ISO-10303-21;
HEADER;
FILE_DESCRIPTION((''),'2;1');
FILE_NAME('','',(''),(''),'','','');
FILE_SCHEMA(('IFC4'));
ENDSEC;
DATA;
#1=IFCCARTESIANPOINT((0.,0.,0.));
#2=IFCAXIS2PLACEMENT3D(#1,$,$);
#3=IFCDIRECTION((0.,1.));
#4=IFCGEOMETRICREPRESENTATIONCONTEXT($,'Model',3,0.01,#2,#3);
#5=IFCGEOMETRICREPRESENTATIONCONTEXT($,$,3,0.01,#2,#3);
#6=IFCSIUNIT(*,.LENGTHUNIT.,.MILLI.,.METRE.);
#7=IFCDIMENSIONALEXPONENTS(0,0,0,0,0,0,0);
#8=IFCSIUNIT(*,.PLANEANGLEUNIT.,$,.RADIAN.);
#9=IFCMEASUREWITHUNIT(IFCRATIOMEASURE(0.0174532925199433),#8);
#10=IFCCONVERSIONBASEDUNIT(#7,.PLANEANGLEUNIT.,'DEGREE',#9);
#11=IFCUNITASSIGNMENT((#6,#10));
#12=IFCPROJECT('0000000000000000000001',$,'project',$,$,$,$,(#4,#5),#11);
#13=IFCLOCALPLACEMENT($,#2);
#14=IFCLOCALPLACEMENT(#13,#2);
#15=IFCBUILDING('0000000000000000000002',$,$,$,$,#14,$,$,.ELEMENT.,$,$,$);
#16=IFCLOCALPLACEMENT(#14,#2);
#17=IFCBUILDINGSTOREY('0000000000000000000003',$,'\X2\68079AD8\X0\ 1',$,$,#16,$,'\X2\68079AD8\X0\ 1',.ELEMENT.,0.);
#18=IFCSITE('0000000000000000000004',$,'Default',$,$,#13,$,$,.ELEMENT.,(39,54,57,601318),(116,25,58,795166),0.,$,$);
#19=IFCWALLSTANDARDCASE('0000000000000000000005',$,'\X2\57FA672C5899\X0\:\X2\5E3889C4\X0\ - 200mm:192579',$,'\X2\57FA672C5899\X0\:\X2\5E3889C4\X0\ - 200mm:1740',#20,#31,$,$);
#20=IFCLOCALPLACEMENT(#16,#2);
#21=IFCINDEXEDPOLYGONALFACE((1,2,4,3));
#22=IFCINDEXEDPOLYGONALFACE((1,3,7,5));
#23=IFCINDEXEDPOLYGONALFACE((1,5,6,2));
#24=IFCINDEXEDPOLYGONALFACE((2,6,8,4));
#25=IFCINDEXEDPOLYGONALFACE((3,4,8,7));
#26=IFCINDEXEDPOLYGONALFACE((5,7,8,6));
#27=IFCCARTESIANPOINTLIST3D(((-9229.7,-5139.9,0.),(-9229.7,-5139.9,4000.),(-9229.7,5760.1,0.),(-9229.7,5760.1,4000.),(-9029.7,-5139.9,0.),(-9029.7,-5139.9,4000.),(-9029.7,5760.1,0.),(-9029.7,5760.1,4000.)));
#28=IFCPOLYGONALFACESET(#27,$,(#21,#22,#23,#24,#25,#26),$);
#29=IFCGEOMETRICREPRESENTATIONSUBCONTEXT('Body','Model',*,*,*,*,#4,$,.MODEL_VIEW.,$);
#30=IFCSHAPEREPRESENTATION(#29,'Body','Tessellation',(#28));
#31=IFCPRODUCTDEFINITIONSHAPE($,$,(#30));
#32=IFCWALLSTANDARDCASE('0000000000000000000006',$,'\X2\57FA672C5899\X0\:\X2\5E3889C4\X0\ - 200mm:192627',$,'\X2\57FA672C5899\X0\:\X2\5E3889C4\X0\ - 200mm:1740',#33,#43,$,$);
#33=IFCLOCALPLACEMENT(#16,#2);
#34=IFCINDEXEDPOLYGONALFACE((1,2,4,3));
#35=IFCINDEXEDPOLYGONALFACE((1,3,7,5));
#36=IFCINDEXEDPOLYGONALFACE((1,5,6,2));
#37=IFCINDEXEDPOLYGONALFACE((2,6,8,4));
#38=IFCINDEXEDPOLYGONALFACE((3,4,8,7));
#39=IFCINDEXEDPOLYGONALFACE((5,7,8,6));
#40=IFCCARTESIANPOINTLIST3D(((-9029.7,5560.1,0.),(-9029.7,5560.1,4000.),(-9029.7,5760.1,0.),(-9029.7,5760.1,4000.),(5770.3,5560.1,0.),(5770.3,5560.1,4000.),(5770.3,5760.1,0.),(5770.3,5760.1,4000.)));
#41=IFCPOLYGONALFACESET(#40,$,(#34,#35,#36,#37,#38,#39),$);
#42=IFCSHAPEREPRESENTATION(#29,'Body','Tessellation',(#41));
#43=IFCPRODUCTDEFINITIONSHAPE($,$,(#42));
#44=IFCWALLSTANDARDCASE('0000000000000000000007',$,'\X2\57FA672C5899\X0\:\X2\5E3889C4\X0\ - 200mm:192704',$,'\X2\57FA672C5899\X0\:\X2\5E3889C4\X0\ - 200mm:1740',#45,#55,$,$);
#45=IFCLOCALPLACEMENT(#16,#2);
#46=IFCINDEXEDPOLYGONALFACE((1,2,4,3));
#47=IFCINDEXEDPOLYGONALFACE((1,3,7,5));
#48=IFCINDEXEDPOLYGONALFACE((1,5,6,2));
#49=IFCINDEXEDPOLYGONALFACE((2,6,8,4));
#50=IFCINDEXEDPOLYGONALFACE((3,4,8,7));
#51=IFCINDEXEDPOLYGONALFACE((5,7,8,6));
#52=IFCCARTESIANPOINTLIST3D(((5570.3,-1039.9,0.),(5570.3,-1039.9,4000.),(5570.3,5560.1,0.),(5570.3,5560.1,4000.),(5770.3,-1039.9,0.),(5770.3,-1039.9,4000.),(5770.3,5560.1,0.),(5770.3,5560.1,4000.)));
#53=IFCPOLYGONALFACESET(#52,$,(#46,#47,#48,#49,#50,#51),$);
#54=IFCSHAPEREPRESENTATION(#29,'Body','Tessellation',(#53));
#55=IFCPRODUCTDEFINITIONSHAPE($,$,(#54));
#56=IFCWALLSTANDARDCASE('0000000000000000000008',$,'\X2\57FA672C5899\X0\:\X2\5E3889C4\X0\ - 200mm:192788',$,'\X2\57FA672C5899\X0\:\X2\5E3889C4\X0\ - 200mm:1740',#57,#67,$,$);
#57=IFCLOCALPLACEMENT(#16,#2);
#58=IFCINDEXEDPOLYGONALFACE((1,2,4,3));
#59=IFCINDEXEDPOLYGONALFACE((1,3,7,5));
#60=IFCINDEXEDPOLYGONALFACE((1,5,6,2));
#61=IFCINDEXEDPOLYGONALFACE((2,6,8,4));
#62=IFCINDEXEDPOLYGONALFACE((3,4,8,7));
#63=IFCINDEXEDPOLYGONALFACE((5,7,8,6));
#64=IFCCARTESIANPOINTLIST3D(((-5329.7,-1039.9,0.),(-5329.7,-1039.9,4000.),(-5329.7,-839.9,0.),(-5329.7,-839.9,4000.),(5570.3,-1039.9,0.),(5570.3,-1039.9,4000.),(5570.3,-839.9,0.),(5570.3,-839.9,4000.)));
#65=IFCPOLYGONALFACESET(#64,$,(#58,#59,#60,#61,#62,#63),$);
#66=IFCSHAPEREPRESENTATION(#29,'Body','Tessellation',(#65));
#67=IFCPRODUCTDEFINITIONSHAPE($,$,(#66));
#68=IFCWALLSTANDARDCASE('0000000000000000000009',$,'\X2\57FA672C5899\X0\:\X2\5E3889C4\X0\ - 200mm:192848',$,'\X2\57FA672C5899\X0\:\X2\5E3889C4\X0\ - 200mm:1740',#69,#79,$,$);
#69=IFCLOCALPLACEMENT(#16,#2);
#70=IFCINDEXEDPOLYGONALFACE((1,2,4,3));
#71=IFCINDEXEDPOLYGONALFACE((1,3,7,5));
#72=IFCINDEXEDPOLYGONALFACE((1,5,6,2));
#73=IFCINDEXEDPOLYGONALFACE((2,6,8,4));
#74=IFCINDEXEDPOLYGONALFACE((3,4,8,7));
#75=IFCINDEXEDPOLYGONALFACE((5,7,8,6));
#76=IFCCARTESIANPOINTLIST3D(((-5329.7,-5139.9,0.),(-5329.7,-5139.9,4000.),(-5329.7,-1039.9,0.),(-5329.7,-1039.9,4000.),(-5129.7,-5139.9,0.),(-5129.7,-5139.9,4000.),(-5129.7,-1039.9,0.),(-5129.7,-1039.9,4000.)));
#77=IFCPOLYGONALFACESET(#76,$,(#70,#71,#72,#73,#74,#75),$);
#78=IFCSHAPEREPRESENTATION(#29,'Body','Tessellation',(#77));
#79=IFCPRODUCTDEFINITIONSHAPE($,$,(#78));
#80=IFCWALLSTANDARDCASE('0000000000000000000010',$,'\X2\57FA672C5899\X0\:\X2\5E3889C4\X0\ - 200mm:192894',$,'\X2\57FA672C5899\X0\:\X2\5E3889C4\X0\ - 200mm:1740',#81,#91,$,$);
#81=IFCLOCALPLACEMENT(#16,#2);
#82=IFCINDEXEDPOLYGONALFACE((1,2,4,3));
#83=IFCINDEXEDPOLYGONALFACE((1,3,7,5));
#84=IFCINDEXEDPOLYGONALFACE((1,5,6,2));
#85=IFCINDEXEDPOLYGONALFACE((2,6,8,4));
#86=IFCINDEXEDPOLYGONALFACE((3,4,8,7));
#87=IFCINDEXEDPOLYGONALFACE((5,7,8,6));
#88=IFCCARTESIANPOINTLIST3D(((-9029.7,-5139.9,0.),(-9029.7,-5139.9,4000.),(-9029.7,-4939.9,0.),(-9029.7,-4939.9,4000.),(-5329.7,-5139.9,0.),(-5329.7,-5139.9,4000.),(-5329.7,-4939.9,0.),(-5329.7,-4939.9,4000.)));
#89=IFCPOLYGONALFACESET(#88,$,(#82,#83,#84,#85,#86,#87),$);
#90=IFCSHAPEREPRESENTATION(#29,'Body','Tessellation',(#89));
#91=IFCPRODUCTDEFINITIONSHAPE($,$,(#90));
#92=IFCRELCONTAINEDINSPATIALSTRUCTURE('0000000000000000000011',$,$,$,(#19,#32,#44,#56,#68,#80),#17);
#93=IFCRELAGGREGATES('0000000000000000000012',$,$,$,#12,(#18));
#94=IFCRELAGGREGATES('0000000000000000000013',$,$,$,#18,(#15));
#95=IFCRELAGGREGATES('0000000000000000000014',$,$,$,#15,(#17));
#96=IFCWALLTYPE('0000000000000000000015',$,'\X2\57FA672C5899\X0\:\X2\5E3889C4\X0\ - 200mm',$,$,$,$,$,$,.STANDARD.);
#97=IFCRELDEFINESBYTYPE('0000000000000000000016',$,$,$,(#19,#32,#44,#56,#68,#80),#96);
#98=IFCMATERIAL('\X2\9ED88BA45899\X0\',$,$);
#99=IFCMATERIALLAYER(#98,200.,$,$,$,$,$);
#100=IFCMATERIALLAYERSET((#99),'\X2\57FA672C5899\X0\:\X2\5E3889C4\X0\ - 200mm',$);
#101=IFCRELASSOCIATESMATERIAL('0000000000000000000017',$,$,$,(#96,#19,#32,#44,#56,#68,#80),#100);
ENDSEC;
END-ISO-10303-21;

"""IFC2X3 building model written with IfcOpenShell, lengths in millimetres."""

from ifc_helpers import new_model, entity, si_unit, converted_unit, direction, frame, frame_2d, origin, place, context, subcontext, project, spatial, rectangle, extrude, material, layer, layer_set, layer_usage, type_object, element, save


model = new_model("IFC2X3")

# Units and contexts
model_context = context("Model", 3, precision=0.01, world=origin(), true_north=direction((0.0, 1.0)))
context_of_model = context(None, 3, precision=0.01, world=origin(), true_north=direction((0.0, 1.0)))
body_context = subcontext(model_context, "Body", "Model", "MODEL_VIEW")
ifc_project = project(units=[si_unit("LENGTHUNIT", "METRE", prefix="MILLI"), converted_unit("PLANEANGLEUNIT", "DEGREE", entity("IfcRatioMeasure", 0.0174532925199433), si_unit("PLANEANGLEUNIT", "RADIAN"), dimensions=[0, 0, 0, 0, 0, 0, 0])], contexts=[model_context, context_of_model])

# Site, building, storey
site_placement = place(None, origin())
site = spatial("IfcSite", under=ifc_project, at=site_placement, Name="Default", CompositionType="ELEMENT", RefLatitude=(39, 54, 57, 601318), RefLongitude=(116, 25, 58, 795166), RefElevation=0.0)
building_placement = place(site_placement, origin())
building = spatial("IfcBuilding", under=site, at=building_placement, CompositionType="ELEMENT")
storey_placement = place(building_placement, origin())
storey = spatial("IfcBuildingStorey", under=building, at=storey_placement, Name="标高 1", LongName="标高 1", CompositionType="ELEMENT", Elevation=0.0)

# Walls
ifc_material = material(Name="默认墙")
ifc_layer = layer(ifc_material, 200.0)
ifc_layer_set = layer_set([ifc_layer], Name="基本墙:常规 - 200mm")
ifc_layer_usage_1 = layer_usage(ifc_layer_set, "AXIS2", "NEGATIVE", 100.0)
wall_type = type_object("IfcWallType", Name="基本墙:常规 - 200mm", PredefinedType="STANDARD", material=ifc_layer_set)
wall_1_placement = place(storey_placement, frame((-9129.7, -5139.9, 0.0), z_axis=(0.0, 0.0, 1.0), x_axis=(0.0, 1.0, 0.0)))
element("IfcWallStandardCase", 1, at=wall_1_placement, inside=storey, type_object=wall_type, material=ifc_layer_usage_1, Name="基本墙:常规 - 200mm:192579", ObjectType="基本墙:常规 - 200mm:1740", context=body_context, shape_type="SweptSolid", body=[
    extrude(rectangle(XDim=10900.0, YDim=200.0, at=frame_2d((5450.0, 0.0), x_axis=(-1.0, 0.0))), origin(), (0.0, 0.0, 1.0), 4000.0),
])
ifc_layer_usage_2 = layer_usage(ifc_layer_set, "AXIS2", "NEGATIVE", 100.0)
wall_2_placement = place(storey_placement, frame((-9029.7, 5660.1, 0.0)))
element("IfcWallStandardCase", 2, at=wall_2_placement, inside=storey, type_object=wall_type, material=ifc_layer_usage_2, Name="基本墙:常规 - 200mm:192627", ObjectType="基本墙:常规 - 200mm:1740", context=body_context, shape_type="SweptSolid", body=[
    extrude(rectangle(XDim=14800.0, YDim=200.0, at=frame_2d((7400.0, 0.0), x_axis=(-1.0, 0.0))), origin(), (0.0, 0.0, 1.0), 4000.0),
])
ifc_layer_usage_3 = layer_usage(ifc_layer_set, "AXIS2", "NEGATIVE", 100.0)
wall_3_placement = place(storey_placement, frame((5670.3, 5560.1, 0.0), z_axis=(0.0, 0.0, 1.0), x_axis=(0.0, -1.0, 0.0)))
element("IfcWallStandardCase", 3, at=wall_3_placement, inside=storey, type_object=wall_type, material=ifc_layer_usage_3, Name="基本墙:常规 - 200mm:192704", ObjectType="基本墙:常规 - 200mm:1740", context=body_context, shape_type="SweptSolid", body=[
    extrude(rectangle(XDim=6600.0, YDim=200.0, at=frame_2d((3300.0, 0.0), x_axis=(-1.0, 0.0))), origin(), (0.0, 0.0, 1.0), 4000.0),
])
ifc_layer_usage_4 = layer_usage(ifc_layer_set, "AXIS2", "NEGATIVE", 100.0)
wall_4_placement = place(storey_placement, frame((5570.3, -939.9, 0.0), z_axis=(0.0, 0.0, 1.0), x_axis=(-1.0, 0.0, 0.0)))
element("IfcWallStandardCase", 4, at=wall_4_placement, inside=storey, type_object=wall_type, material=ifc_layer_usage_4, Name="基本墙:常规 - 200mm:192788", ObjectType="基本墙:常规 - 200mm:1740", context=body_context, shape_type="SweptSolid", body=[
    extrude(rectangle(XDim=10900.0, YDim=200.0, at=frame_2d((5450.0, 0.0), x_axis=(-1.0, 0.0))), origin(), (0.0, 0.0, 1.0), 4000.0),
])
ifc_layer_usage_5 = layer_usage(ifc_layer_set, "AXIS2", "NEGATIVE", 100.0)
wall_5_placement = place(storey_placement, frame((-5229.7, -1039.9, 0.0), z_axis=(0.0, 0.0, 1.0), x_axis=(0.0, -1.0, 0.0)))
element("IfcWallStandardCase", 5, at=wall_5_placement, inside=storey, type_object=wall_type, material=ifc_layer_usage_5, Name="基本墙:常规 - 200mm:192848", ObjectType="基本墙:常规 - 200mm:1740", context=body_context, shape_type="SweptSolid", body=[
    extrude(rectangle(XDim=4100.0, YDim=200.0, at=frame_2d((2050.0, 0.0), x_axis=(-1.0, 0.0))), origin(), (0.0, 0.0, 1.0), 4000.0),
])
ifc_layer_usage_6 = layer_usage(ifc_layer_set, "AXIS2", "NEGATIVE", 100.0)
wall_6_placement = place(storey_placement, frame((-5329.7, -5039.9, 0.0), z_axis=(0.0, 0.0, 1.0), x_axis=(-1.0, 0.0, 0.0)))
element("IfcWallStandardCase", 6, at=wall_6_placement, inside=storey, type_object=wall_type, material=ifc_layer_usage_6, Name="基本墙:常规 - 200mm:192894", ObjectType="基本墙:常规 - 200mm:1740", context=body_context, shape_type="SweptSolid", body=[
    extrude(rectangle(XDim=3700.0, YDim=200.0, at=frame_2d((1850.0, 0.0), x_axis=(-1.0, 0.0))), origin(), (0.0, 0.0, 1.0), 4000.0),
])

save(model, "model.ifc")
